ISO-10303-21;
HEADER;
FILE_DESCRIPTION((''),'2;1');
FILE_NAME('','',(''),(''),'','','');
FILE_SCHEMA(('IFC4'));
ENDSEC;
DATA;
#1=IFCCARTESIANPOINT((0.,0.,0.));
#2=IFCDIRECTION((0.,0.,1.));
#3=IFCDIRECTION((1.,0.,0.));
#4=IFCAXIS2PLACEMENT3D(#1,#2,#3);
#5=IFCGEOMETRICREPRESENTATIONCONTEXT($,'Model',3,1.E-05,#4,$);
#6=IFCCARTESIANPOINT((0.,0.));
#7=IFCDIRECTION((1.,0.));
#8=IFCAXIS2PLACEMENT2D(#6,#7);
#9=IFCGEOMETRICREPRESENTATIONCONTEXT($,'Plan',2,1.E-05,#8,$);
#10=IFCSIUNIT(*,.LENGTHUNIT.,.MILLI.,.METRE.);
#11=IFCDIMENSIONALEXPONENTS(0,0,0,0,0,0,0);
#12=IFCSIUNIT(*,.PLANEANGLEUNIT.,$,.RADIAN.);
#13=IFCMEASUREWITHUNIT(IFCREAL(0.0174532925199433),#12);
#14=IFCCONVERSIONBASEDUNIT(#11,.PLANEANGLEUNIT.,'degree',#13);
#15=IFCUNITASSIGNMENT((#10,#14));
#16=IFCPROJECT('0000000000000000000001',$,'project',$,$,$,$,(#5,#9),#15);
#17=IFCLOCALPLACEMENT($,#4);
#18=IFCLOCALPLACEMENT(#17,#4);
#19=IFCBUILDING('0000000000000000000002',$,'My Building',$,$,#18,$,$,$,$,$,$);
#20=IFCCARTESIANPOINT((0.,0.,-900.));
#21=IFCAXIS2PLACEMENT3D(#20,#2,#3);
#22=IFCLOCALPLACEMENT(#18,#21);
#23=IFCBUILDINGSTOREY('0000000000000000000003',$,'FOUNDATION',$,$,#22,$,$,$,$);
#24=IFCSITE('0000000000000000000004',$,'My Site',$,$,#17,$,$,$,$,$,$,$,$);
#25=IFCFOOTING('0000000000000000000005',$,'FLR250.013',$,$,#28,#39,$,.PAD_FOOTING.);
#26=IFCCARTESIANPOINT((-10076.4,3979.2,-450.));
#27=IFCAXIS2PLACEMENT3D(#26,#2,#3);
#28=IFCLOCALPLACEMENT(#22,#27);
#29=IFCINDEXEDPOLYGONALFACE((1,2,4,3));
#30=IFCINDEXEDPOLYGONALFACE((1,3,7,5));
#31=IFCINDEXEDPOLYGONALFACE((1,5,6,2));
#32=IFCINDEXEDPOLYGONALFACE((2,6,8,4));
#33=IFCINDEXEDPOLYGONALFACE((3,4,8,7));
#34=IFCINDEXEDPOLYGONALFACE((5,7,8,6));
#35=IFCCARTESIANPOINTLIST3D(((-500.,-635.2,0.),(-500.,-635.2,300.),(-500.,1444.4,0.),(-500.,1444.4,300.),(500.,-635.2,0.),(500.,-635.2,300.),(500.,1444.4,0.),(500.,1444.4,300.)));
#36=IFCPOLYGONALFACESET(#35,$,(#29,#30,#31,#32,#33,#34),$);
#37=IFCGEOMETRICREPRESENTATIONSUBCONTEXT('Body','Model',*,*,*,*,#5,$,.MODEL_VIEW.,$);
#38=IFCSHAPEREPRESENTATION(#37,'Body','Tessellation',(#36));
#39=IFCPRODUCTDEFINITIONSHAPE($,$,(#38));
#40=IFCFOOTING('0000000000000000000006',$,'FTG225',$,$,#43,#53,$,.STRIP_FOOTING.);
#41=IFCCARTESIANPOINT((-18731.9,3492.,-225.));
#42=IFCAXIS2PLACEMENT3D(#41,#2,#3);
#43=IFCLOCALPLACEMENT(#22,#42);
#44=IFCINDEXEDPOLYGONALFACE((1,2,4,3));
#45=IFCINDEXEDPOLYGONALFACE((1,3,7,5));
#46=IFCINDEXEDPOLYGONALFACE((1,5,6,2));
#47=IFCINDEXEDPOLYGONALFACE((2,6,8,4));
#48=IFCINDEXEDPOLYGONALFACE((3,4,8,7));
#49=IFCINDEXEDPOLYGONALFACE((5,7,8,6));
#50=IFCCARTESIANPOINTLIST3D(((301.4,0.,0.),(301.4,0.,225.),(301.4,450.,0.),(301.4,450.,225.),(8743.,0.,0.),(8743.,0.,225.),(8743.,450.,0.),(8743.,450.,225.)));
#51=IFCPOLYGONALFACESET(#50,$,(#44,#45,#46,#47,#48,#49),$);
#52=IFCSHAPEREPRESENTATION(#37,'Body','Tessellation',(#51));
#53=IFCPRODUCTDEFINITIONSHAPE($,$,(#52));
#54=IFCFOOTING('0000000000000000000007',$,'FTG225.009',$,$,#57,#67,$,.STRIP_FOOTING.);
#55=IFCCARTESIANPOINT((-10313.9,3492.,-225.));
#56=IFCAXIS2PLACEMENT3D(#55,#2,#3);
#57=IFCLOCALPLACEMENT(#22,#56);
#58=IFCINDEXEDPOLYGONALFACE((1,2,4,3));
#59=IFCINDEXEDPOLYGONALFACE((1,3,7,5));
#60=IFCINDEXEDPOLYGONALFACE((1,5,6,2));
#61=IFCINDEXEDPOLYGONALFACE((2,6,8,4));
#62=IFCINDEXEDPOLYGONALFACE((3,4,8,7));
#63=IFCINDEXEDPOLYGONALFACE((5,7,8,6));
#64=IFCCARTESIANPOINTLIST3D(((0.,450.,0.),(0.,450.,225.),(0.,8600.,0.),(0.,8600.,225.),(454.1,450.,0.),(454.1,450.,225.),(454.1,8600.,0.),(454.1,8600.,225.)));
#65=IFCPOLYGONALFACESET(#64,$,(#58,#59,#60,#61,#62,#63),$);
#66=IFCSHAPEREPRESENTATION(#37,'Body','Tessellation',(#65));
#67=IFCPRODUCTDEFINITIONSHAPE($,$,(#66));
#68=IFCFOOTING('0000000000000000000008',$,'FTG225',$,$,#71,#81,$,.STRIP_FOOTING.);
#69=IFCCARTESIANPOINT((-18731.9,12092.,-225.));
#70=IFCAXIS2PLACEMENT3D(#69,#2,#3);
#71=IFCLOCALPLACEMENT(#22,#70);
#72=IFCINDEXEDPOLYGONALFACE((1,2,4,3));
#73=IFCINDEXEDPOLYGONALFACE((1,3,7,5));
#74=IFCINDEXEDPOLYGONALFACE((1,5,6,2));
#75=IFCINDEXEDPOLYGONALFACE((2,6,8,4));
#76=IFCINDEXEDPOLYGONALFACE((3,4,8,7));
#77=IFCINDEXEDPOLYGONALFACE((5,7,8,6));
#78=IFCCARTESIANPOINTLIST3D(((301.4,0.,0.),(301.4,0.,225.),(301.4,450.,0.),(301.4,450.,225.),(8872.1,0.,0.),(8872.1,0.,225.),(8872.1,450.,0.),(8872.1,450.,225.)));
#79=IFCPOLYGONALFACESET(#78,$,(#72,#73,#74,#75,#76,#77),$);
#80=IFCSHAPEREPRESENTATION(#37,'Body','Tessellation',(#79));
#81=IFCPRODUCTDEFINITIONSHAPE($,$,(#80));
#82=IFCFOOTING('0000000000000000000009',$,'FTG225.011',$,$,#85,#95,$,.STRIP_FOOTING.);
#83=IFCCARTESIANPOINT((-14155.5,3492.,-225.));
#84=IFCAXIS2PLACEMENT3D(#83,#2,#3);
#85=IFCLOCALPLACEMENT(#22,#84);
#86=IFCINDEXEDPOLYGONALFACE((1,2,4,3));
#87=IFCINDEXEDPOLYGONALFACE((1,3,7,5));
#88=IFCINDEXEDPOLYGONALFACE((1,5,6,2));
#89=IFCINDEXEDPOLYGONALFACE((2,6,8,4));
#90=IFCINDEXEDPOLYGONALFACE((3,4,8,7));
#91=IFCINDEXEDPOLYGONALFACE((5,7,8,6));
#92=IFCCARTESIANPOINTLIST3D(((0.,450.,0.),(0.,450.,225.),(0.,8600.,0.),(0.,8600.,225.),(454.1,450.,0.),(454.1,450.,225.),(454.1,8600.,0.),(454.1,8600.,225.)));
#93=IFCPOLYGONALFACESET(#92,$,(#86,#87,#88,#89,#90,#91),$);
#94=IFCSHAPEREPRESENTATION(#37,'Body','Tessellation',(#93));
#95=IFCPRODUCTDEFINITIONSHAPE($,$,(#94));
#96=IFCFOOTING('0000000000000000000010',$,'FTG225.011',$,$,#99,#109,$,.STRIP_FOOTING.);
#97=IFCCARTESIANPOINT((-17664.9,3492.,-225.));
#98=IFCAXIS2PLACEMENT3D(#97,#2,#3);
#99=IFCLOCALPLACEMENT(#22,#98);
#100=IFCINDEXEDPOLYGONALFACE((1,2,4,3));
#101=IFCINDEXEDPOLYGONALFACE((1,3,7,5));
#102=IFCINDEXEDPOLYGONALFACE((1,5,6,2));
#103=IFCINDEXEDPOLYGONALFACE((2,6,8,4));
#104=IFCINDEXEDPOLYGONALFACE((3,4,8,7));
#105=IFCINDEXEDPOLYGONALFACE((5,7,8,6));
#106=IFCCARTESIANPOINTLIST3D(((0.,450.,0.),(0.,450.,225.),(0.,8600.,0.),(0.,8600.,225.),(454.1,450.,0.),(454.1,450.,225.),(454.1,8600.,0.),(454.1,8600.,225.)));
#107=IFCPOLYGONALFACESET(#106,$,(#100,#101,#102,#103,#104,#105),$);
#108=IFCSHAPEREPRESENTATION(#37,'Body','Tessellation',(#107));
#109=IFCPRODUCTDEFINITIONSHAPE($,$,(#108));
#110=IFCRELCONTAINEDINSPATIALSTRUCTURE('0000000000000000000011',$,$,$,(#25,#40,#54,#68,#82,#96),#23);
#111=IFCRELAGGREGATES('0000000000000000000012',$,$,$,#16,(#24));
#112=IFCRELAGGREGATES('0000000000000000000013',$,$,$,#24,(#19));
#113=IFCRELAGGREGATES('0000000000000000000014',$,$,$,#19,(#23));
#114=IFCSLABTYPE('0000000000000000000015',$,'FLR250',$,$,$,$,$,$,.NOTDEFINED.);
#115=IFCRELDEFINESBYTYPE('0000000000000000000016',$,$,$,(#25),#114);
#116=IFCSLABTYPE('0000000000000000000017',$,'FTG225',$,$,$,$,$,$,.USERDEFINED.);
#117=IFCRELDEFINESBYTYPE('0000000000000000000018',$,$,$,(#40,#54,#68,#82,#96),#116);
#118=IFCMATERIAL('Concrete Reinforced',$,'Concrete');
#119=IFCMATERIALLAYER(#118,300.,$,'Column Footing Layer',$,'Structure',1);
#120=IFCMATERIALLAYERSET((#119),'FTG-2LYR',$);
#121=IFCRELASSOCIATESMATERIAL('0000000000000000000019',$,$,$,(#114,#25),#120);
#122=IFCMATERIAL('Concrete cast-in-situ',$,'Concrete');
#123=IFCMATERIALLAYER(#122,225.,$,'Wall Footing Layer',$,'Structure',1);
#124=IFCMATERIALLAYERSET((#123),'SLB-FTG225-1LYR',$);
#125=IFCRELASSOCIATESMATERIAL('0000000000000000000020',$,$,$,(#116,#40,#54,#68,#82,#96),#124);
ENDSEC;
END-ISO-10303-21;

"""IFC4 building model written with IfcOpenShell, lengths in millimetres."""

from ifc_helpers import new_model, entity, si_unit, converted_unit, frame, origin_with_axes, origin_2d_with_axis, place, context, subcontext, project, spatial, line, indexed_curve, outline, extrude, material, layer, layer_set, layer_usage, type_object, element, save


model = new_model("IFC4")

# Units and contexts
model_context = context("Model", 3, precision=1e-05, world=origin_with_axes())
plan_context = context("Plan", 2, precision=1e-05, world=origin_2d_with_axis())
body_context = subcontext(model_context, "Body", "Model", "MODEL_VIEW")
ifc_project = project(units=[si_unit("LENGTHUNIT", "METRE", prefix="MILLI"), converted_unit("PLANEANGLEUNIT", "degree", entity("IfcReal", 0.0174532925199433), si_unit("PLANEANGLEUNIT", "RADIAN"), dimensions=[0, 0, 0, 0, 0, 0, 0])], contexts=[model_context, plan_context])

# Site, building, storey
site_placement = place(None, origin_with_axes())
site = spatial("IfcSite", under=ifc_project, at=site_placement, Name="My Site")
building_placement = place(site_placement, origin_with_axes())
building = spatial("IfcBuilding", under=site, at=building_placement, Name="My Building")
storey_placement = place(building_placement, frame((0.0, 0.0, -900.0), z_axis=(0.0, 0.0, 1.0), x_axis=(1.0, 0.0, 0.0)))
storey = spatial("IfcBuildingStorey", under=building, at=storey_placement, Name="FOUNDATION")

# Footings
ifc_material_1 = material(Name="Concrete Reinforced", Category="Concrete")
ifc_layer_1 = layer(ifc_material_1, 300.0, Name="Column Footing Layer", Category="Structure", Priority=1)
ifc_layer_set_1 = layer_set([ifc_layer_1], Name="FTG-2LYR")
slab_type_1 = type_object("IfcSlabType", Name="FLR250", PredefinedType="NOTDEFINED", material=ifc_layer_set_1)
ifc_layer_usage_1 = layer_usage(ifc_layer_set_1, "AXIS3", "POSITIVE", 0.0)
footing_1_placement = place(storey_placement, frame((-10076.4, 3979.2, -450.0), z_axis=(0.0, 0.0, 1.0), x_axis=(1.0, 0.0, 0.0)))
element("IfcFooting", 1, at=footing_1_placement, inside=storey, type_object=slab_type_1, material=ifc_layer_usage_1, Name="FLR250.013", PredefinedType="PAD_FOOTING", context=body_context, shape_type="SweptSolid", body=[
    extrude(outline(indexed_curve([(-500.0, -635.2), (500.0, -635.2), (500.0, 1444.4), (-500.0, 1444.4)], segments=[line(3, 2), line(2, 1), line(1, 4), line(4, 3)], self_intersect=False)), None, (0.0, 0.0, 1.0), 300.0),
])
ifc_material_2 = material(Name="Concrete cast-in-situ", Category="Concrete")
ifc_layer_2 = layer(ifc_material_2, 225.0, Name="Wall Footing Layer", Category="Structure", Priority=1)
ifc_layer_set_2 = layer_set([ifc_layer_2], Name="SLB-FTG225-1LYR")
ifc_layer_usage_2 = layer_usage(ifc_layer_set_2, "AXIS3", "POSITIVE", 0.0)
slab_type_2 = type_object("IfcSlabType", Name="FTG225", PredefinedType="USERDEFINED", material=ifc_layer_set_2)
footing_2_placement = place(storey_placement, frame((-18731.9, 3492.0, -225.0), z_axis=(0.0, 0.0, 1.0), x_axis=(1.0, 0.0, 0.0)))
element("IfcFooting", 2, at=footing_2_placement, inside=storey, type_object=slab_type_2, material=ifc_layer_usage_2, Name="FTG225", PredefinedType="STRIP_FOOTING", context=body_context, shape_type="SweptSolid", body=[
    extrude(outline(indexed_curve([(8743.0, 450.0), (8743.0, 0.0), (301.4, 0.0), (301.4, 450.0)], segments=[line(3, 2), line(2, 1), line(1, 4), line(4, 3)], self_intersect=False)), None, (0.0, 0.0, 1.0), 225.0),
])
ifc_layer_usage_3 = layer_usage(ifc_layer_set_2, "AXIS3", "POSITIVE", 0.0)
footing_3_placement = place(storey_placement, frame((-10313.9, 3492.0, -225.0), z_axis=(0.0, 0.0, 1.0), x_axis=(1.0, 0.0, 0.0)))
element("IfcFooting", 3, at=footing_3_placement, inside=storey, type_object=slab_type_2, material=ifc_layer_usage_3, Name="FTG225.009", PredefinedType="STRIP_FOOTING", context=body_context, shape_type="SweptSolid", body=[
    extrude(outline(indexed_curve([(454.1, 8600.0), (454.1, 450.0), (0.0, 450.0), (0.0, 8600.0)], segments=[line(3, 2), line(2, 1), line(1, 4), line(4, 3)], self_intersect=False)), None, (0.0, 0.0, 1.0), 225.0),
])
ifc_layer_usage_4 = layer_usage(ifc_layer_set_2, "AXIS3", "POSITIVE", 0.0)
footing_4_placement = place(storey_placement, frame((-18731.9, 12092.0, -225.0), z_axis=(0.0, 0.0, 1.0), x_axis=(1.0, 0.0, 0.0)))
element("IfcFooting", 4, at=footing_4_placement, inside=storey, type_object=slab_type_2, material=ifc_layer_usage_4, Name="FTG225", PredefinedType="STRIP_FOOTING", context=body_context, shape_type="SweptSolid", body=[
    extrude(outline(indexed_curve([(301.4, 0.0), (8872.1, 0.0), (8872.1, 450.0), (301.4, 450.0)], segments=[line(3, 2), line(2, 1), line(1, 4), line(4, 3)], self_intersect=False)), None, (0.0, 0.0, 1.0), 225.0),
])
ifc_layer_usage_5 = layer_usage(ifc_layer_set_2, "AXIS3", "POSITIVE", 0.0)
footing_5_placement = place(storey_placement, frame((-14155.5, 3492.0, -225.0), z_axis=(0.0, 0.0, 1.0), x_axis=(1.0, 0.0, 0.0)))
element("IfcFooting", 5, at=footing_5_placement, inside=storey, type_object=slab_type_2, material=ifc_layer_usage_5, Name="FTG225.011", PredefinedType="STRIP_FOOTING", context=body_context, shape_type="SweptSolid", body=[
    extrude(outline(indexed_curve([(454.1, 8600.0), (454.1, 450.0), (0.0, 450.0), (0.0, 8600.0)], segments=[line(3, 2), line(2, 1), line(1, 4), line(4, 3)], self_intersect=False)), None, (0.0, 0.0, 1.0), 225.0),
])
ifc_layer_usage_6 = layer_usage(ifc_layer_set_2, "AXIS3", "POSITIVE", 0.0)
footing_6_placement = place(storey_placement, frame((-17664.9, 3492.0, -225.0), z_axis=(0.0, 0.0, 1.0), x_axis=(1.0, 0.0, 0.0)))
element("IfcFooting", 6, at=footing_6_placement, inside=storey, type_object=slab_type_2, material=ifc_layer_usage_6, Name="FTG225.011", PredefinedType="STRIP_FOOTING", context=body_context, shape_type="SweptSolid", body=[
    extrude(outline(indexed_curve([(454.1, 8600.0), (454.1, 450.0), (0.0, 450.0), (0.0, 8600.0)], segments=[line(3, 2), line(2, 1), line(1, 4), line(4, 3)], self_intersect=False)), None, (0.0, 0.0, 1.0), 225.0),
])

save(model, "model.ifc")
